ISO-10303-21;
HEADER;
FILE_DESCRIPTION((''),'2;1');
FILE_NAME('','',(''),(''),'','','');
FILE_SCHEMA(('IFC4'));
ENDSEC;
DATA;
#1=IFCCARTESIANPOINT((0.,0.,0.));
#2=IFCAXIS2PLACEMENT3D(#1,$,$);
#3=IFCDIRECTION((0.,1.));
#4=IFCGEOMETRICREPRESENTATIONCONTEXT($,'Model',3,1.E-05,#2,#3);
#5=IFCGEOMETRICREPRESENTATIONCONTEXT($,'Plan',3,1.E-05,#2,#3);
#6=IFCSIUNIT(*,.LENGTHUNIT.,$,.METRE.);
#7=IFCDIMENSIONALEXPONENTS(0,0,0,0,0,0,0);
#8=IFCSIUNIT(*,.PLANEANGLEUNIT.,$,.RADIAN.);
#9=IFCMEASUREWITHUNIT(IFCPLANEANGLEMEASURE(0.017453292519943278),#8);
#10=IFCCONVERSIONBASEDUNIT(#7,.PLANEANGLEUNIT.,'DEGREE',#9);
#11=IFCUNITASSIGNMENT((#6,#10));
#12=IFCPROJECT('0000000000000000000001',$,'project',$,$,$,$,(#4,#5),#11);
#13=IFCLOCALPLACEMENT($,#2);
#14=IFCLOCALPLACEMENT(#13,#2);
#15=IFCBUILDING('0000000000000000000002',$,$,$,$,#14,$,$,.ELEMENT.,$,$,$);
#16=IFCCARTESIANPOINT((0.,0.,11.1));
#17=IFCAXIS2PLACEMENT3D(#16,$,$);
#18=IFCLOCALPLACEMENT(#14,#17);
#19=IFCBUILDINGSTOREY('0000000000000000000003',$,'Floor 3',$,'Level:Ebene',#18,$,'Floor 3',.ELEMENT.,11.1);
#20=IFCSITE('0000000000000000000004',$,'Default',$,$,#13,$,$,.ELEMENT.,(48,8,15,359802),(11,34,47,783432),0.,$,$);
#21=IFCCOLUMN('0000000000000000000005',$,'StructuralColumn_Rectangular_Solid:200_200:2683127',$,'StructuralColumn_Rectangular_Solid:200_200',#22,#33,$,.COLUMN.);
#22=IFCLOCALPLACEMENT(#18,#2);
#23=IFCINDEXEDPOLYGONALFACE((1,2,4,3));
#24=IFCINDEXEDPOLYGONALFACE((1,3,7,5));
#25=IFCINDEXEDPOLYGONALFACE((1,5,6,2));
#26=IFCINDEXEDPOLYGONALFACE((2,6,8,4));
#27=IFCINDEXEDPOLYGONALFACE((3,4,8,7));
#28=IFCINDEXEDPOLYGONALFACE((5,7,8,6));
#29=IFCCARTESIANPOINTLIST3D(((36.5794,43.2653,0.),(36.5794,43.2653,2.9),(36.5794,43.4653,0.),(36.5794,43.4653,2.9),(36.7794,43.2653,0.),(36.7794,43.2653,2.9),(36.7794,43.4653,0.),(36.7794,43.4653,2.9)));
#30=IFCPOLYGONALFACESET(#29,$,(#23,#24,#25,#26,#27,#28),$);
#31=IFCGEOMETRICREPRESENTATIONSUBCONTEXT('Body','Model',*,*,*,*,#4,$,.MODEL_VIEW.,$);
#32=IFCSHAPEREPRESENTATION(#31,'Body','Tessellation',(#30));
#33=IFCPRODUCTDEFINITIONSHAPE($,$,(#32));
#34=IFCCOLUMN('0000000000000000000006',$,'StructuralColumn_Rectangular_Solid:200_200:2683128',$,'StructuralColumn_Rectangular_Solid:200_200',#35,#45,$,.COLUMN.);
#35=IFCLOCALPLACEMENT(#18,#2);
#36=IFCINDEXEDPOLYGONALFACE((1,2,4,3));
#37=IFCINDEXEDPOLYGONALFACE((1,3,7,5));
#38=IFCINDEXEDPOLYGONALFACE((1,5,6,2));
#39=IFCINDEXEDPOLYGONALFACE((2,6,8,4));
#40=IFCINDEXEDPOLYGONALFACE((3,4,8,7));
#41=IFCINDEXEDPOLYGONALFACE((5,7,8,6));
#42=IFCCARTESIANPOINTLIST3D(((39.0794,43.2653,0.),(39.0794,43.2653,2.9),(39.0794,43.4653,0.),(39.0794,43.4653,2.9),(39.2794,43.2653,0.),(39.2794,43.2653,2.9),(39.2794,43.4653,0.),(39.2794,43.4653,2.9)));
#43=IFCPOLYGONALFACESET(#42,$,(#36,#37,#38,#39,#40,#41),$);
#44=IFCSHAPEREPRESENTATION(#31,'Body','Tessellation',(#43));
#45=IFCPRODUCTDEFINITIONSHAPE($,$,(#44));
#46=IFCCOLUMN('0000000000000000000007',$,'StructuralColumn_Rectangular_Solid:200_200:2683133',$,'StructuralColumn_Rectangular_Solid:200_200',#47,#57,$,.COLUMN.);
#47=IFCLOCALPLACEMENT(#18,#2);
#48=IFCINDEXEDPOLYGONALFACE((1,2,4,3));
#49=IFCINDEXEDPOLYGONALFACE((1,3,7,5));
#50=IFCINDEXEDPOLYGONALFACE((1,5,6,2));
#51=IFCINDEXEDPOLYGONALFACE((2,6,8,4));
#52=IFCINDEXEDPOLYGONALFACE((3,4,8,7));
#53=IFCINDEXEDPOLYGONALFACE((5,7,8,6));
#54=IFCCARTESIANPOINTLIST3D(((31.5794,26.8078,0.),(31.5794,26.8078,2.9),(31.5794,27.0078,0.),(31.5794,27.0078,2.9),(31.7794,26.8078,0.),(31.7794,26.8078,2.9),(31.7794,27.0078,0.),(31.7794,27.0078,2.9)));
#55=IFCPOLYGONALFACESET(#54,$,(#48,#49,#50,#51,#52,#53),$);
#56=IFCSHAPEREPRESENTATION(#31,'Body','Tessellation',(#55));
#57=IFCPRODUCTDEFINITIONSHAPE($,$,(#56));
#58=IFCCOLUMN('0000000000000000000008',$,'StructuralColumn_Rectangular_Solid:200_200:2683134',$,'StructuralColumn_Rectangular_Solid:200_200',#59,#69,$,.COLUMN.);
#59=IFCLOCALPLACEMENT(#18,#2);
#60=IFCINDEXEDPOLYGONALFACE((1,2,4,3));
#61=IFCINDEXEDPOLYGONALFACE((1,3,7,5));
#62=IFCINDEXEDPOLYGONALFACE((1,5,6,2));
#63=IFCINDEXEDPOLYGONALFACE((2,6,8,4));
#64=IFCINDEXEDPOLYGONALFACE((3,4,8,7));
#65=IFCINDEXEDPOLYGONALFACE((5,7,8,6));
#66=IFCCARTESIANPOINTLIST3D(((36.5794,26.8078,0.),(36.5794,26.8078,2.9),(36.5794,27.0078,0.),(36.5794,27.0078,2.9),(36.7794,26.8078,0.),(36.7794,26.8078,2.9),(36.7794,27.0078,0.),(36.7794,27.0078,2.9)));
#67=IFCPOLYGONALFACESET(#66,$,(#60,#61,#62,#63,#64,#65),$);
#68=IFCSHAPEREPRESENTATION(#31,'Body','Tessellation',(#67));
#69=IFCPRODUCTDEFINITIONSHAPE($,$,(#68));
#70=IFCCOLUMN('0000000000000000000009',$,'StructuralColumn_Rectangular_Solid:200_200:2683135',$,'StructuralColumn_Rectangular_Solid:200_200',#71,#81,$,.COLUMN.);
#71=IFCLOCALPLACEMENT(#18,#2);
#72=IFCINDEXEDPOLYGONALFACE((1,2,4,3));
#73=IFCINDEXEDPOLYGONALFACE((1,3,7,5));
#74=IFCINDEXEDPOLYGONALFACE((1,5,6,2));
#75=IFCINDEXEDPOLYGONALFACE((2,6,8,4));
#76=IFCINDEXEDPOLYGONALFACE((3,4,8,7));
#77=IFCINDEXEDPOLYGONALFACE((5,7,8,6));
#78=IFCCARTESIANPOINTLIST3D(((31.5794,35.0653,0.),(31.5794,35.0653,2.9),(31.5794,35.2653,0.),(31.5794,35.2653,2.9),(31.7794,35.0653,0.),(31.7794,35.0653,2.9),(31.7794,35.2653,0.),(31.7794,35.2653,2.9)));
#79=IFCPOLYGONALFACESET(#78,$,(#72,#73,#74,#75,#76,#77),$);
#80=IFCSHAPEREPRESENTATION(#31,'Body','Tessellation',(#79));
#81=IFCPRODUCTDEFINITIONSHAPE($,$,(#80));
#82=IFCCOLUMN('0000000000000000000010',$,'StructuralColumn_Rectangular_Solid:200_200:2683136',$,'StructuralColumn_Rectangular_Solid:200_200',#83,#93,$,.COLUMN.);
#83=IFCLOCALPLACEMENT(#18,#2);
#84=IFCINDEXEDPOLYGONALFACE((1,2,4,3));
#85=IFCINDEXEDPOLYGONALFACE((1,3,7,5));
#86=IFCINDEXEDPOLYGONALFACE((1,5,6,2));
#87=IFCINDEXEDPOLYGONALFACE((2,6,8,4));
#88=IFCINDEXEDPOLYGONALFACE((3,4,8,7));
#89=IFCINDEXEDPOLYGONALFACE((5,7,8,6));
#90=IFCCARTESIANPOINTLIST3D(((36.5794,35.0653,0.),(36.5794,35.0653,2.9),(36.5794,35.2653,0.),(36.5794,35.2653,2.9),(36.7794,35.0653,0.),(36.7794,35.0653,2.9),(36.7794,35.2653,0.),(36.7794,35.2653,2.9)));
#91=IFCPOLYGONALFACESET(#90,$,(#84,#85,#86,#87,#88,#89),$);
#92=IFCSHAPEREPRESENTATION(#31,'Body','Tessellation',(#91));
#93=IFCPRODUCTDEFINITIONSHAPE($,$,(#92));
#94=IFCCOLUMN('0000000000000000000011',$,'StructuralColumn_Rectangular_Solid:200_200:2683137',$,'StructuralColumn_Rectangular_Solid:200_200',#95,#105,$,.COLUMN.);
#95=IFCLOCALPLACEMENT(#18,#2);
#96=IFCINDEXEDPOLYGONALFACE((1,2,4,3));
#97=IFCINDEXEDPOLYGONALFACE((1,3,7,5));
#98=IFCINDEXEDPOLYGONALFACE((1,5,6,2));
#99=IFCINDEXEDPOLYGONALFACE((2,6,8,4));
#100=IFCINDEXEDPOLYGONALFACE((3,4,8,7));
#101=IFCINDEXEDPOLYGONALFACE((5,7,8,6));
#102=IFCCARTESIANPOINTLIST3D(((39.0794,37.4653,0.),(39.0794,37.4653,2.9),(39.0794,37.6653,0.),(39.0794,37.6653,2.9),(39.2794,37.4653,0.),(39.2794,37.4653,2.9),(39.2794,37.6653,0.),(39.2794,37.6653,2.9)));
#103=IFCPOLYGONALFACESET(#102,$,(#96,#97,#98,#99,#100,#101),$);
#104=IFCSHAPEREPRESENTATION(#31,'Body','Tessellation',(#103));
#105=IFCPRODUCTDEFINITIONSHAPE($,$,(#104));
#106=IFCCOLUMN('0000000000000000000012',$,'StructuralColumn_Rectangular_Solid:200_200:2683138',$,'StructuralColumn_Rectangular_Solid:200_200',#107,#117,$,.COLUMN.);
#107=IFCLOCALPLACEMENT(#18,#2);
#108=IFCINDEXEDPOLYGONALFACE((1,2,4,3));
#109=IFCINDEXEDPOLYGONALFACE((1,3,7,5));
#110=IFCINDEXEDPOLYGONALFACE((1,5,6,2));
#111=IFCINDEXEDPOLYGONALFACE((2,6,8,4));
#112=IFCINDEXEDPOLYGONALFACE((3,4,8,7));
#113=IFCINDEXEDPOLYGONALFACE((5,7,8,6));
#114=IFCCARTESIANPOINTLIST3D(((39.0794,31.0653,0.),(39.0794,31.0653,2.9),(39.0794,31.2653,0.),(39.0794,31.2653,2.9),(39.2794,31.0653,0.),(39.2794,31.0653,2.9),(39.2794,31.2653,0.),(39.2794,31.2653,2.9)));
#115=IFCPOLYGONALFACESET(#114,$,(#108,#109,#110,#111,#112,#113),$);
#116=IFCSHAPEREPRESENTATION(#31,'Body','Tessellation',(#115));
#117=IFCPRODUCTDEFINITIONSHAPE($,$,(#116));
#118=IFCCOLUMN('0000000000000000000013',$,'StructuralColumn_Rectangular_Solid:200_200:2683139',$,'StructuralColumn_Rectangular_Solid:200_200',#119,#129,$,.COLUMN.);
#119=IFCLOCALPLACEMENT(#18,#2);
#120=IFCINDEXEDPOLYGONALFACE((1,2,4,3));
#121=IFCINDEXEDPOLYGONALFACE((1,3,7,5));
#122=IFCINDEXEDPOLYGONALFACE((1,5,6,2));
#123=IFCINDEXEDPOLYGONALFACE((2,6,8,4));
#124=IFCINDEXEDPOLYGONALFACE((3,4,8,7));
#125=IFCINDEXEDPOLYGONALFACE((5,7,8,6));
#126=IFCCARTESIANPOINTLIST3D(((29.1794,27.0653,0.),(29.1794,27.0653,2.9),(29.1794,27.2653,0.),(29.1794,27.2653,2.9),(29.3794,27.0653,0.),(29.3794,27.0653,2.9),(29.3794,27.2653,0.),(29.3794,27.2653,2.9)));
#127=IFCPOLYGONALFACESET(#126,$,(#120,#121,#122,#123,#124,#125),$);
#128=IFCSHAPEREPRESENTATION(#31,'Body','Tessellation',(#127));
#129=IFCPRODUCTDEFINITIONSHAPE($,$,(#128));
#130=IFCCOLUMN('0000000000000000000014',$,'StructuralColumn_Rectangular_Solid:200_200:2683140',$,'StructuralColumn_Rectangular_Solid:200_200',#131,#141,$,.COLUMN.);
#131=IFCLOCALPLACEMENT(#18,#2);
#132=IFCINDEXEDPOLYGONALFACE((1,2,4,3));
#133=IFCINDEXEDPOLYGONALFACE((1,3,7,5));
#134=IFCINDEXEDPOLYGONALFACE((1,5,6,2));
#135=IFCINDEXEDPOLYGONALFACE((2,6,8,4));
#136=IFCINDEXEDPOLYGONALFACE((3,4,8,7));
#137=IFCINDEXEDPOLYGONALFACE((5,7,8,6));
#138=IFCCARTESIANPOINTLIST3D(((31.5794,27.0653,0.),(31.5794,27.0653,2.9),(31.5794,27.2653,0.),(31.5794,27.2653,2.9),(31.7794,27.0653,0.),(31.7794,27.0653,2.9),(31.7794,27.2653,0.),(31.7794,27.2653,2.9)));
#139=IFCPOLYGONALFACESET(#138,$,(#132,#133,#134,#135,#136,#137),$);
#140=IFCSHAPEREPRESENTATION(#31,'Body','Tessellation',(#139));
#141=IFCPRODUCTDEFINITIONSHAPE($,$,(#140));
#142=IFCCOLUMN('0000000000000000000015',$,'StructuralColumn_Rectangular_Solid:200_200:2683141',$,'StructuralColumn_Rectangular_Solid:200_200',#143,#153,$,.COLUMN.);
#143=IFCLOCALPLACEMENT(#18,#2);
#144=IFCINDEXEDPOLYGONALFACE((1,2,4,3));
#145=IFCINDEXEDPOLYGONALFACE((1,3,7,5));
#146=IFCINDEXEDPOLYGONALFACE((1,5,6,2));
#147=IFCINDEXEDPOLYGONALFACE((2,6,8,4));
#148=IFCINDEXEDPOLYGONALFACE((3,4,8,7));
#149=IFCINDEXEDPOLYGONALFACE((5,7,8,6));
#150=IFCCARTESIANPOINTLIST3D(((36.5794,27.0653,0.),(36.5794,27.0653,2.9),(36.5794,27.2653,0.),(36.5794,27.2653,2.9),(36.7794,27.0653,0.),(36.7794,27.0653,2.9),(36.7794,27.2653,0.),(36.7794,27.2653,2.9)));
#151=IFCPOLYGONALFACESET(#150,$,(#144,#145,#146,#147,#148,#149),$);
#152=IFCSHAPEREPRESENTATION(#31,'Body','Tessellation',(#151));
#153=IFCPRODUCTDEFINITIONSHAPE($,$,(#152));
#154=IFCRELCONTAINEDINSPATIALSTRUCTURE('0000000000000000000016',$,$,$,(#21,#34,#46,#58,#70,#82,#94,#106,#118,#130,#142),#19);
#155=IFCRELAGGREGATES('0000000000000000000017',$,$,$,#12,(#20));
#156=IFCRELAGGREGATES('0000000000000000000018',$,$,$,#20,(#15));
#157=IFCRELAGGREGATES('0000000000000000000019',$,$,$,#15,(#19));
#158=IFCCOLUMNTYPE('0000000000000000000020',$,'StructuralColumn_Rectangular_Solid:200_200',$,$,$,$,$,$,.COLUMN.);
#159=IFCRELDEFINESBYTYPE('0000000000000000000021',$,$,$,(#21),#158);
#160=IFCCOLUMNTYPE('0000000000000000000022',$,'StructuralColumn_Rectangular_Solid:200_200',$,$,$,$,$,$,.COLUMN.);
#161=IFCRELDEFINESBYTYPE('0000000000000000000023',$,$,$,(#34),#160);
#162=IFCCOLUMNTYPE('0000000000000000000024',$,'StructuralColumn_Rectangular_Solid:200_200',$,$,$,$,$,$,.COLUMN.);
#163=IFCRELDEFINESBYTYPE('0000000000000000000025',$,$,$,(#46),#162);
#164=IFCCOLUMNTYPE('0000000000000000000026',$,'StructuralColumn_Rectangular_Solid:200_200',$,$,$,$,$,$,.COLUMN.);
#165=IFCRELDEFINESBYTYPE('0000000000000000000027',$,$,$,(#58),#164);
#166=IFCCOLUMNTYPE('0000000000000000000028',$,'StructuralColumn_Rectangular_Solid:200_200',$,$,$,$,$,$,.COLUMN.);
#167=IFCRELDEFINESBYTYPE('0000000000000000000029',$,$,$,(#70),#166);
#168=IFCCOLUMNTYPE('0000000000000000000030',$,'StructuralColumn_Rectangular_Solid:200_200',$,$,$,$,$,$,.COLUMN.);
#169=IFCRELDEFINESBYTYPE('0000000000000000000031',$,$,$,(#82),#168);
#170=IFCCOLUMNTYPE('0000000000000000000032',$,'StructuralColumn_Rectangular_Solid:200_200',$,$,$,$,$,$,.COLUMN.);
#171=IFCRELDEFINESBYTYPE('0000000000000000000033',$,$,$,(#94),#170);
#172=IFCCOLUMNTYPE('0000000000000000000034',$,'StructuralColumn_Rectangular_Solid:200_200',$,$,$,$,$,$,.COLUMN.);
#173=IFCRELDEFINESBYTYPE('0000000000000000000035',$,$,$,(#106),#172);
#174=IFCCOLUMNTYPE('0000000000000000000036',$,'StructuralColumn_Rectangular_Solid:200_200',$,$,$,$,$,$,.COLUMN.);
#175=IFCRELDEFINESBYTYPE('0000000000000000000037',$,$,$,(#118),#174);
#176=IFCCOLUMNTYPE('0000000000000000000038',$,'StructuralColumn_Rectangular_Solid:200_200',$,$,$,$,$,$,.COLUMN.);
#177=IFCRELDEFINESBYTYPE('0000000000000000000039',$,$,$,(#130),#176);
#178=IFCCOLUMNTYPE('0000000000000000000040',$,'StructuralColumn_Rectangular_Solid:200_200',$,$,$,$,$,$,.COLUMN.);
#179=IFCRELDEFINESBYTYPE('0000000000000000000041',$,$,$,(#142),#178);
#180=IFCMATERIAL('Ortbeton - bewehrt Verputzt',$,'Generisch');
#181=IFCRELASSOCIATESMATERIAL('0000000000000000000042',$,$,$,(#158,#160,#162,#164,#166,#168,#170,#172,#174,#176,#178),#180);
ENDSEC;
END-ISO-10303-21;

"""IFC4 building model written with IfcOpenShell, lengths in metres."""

from ifc_helpers import new_model, entity, si_unit, converted_unit, direction, frame, frame_2d, origin, origin_2d_with_axis, place, context, subcontext, project, spatial, rectangle, extrude, source, transform, mapped, material, material_profile, profile_set, type_object, type_shapes, element, save


model = new_model("IFC4")

# Units and contexts
model_context = context("Model", 3, precision=1e-05, world=origin(), true_north=direction((0.0, 1.0)))
plan_context = context("Plan", 3, precision=1e-05, world=origin(), true_north=direction((0.0, 1.0)))
body_context = subcontext(model_context, "Body", "Model", "MODEL_VIEW")
ifc_project = project(units=[si_unit("LENGTHUNIT", "METRE"), converted_unit("PLANEANGLEUNIT", "DEGREE", entity("IfcPlaneAngleMeasure", 0.017453292519943278), si_unit("PLANEANGLEUNIT", "RADIAN"), dimensions=[0, 0, 0, 0, 0, 0, 0])], contexts=[model_context, plan_context])

# Site, building, storey
site_placement = place(None, origin())
site = spatial("IfcSite", under=ifc_project, at=site_placement, Name="Default", CompositionType="ELEMENT", RefLatitude=(48, 8, 15, 359802), RefLongitude=(11, 34, 47, 783432), RefElevation=0.0)
building_placement = place(site_placement, origin())
building = spatial("IfcBuilding", under=site, at=building_placement, CompositionType="ELEMENT")
storey_placement = place(building_placement, frame((0.0, 0.0, 11.1)))
storey = spatial("IfcBuildingStorey", under=building, at=storey_placement, Name="Floor 3", ObjectType="Level:Ebene", LongName="Floor 3", CompositionType="ELEMENT", Elevation=11.1)

# Columns
ifc_material_1 = material(Name="Ortbeton - bewehrt Verputzt", Category="Generisch")
ifc_material_profile = material_profile(ifc_material_1, rectangle(XDim=0.2, YDim=0.2, at=frame_2d((0.0, 0.0), x_axis=(1.0, 0.0))), Name="200_200")
ifc_profile_set = profile_set([ifc_material_profile], Name="200_200")
column_type_1 = type_object("IfcColumnType", Name="StructuralColumn_Rectangular_Solid:200_200", PredefinedType="COLUMN", material=ifc_profile_set)
shared_shape_1 = source(origin(), body_context, "Body", "SweptSolid", [
    extrude(rectangle(XDim=0.2, YDim=0.2, at=frame_2d((0.0, 0.0), x_axis=(1.0, 0.0))), frame((36.6794, 43.3653, 11.1), z_axis=(0.0, 0.0, 1.0), x_axis=(-1.0, 0.0, 0.0)), (0.0, 0.0, 1.0), 2.9),
])
type_shapes(column_type_1, [shared_shape_1])
column_1_placement = place(storey_placement, frame((0.0, 0.0, -11.1)))
element("IfcColumn", 1, at=column_1_placement, inside=storey, type_object=column_type_1, Name="StructuralColumn_Rectangular_Solid:200_200:2683127", ObjectType="StructuralColumn_Rectangular_Solid:200_200", PredefinedType="COLUMN", context=body_context, shape_type="MappedRepresentation", body=[
    mapped(shared_shape_1, transform((0.0, 0.0, 0.0), scale=1.0)),
])
column_type_2 = type_object("IfcColumnType", Name="StructuralColumn_Rectangular_Solid:200_200", PredefinedType="COLUMN", material=ifc_profile_set)
shared_shape_2 = source(origin(), body_context, "Body", "SweptSolid", [
    extrude(rectangle(XDim=0.2, YDim=0.2, at=frame_2d((0.0, 0.0), x_axis=(1.0, 0.0))), frame((39.1794, 43.3653, 11.1), z_axis=(0.0, 0.0, 1.0), x_axis=(-1.0, 0.0, 0.0)), (0.0, 0.0, 1.0), 2.9),
])
type_shapes(column_type_2, [shared_shape_2])
column_2_placement = place(storey_placement, frame((0.0, 0.0, -11.1)))
element("IfcColumn", 2, at=column_2_placement, inside=storey, type_object=column_type_2, Name="StructuralColumn_Rectangular_Solid:200_200:2683128", ObjectType="StructuralColumn_Rectangular_Solid:200_200", PredefinedType="COLUMN", context=body_context, shape_type="MappedRepresentation", body=[
    mapped(shared_shape_2, transform((0.0, 0.0, 0.0), scale=1.0)),
])
column_type_3 = type_object("IfcColumnType", Name="StructuralColumn_Rectangular_Solid:200_200", PredefinedType="COLUMN", material=ifc_profile_set)
shared_shape_3 = source(origin(), body_context, "Body", "SweptSolid", [
    extrude(rectangle(XDim=0.2, YDim=0.2, at=frame_2d((0.0, 0.0), x_axis=(1.0, 0.0))), frame((31.6794, 26.9078, 11.1), z_axis=(0.0, 0.0, 1.0), x_axis=(-1.0, 0.0, 0.0)), (0.0, 0.0, 1.0), 2.9),
])
type_shapes(column_type_3, [shared_shape_3])
column_3_placement = place(storey_placement, frame((0.0, 0.0, -11.1)))
element("IfcColumn", 3, at=column_3_placement, inside=storey, type_object=column_type_3, Name="StructuralColumn_Rectangular_Solid:200_200:2683133", ObjectType="StructuralColumn_Rectangular_Solid:200_200", PredefinedType="COLUMN", context=body_context, shape_type="MappedRepresentation", body=[
    mapped(shared_shape_3, transform((0.0, 0.0, 0.0), scale=1.0)),
])
column_type_4 = type_object("IfcColumnType", Name="StructuralColumn_Rectangular_Solid:200_200", PredefinedType="COLUMN", material=ifc_profile_set)
shared_shape_4 = source(origin(), body_context, "Body", "SweptSolid", [
    extrude(rectangle(XDim=0.2, YDim=0.2, at=origin_2d_with_axis()), frame((36.6794, 26.9078, 11.1), z_axis=(0.0, 0.0, 1.0), x_axis=(-1.0, 0.0, 0.0)), (0.0, 0.0, 1.0), 2.9),
])
type_shapes(column_type_4, [shared_shape_4])
column_4_placement = place(storey_placement, frame((0.0, 0.0, -11.1)))
element("IfcColumn", 4, at=column_4_placement, inside=storey, type_object=column_type_4, Name="StructuralColumn_Rectangular_Solid:200_200:2683134", ObjectType="StructuralColumn_Rectangular_Solid:200_200", PredefinedType="COLUMN", context=body_context, shape_type="MappedRepresentation", body=[
    mapped(shared_shape_4, transform((0.0, 0.0, 0.0), scale=1.0)),
])
column_type_5 = type_object("IfcColumnType", Name="StructuralColumn_Rectangular_Solid:200_200", PredefinedType="COLUMN", material=ifc_profile_set)
shared_shape_5 = source(origin(), body_context, "Body", "SweptSolid", [
    extrude(rectangle(XDim=0.2, YDim=0.2, at=origin_2d_with_axis()), frame((31.6794, 35.1653, 11.1), z_axis=(0.0, 0.0, 1.0), x_axis=(-1.0, 0.0, 0.0)), (0.0, 0.0, 1.0), 2.9),
])
type_shapes(column_type_5, [shared_shape_5])
column_5_placement = place(storey_placement, frame((0.0, 0.0, -11.1)))
element("IfcColumn", 5, at=column_5_placement, inside=storey, type_object=column_type_5, Name="StructuralColumn_Rectangular_Solid:200_200:2683135", ObjectType="StructuralColumn_Rectangular_Solid:200_200", PredefinedType="COLUMN", context=body_context, shape_type="MappedRepresentation", body=[
    mapped(shared_shape_5, transform((0.0, 0.0, 0.0), scale=1.0)),
])
column_type_6 = type_object("IfcColumnType", Name="StructuralColumn_Rectangular_Solid:200_200", PredefinedType="COLUMN", material=ifc_profile_set)
shared_shape_6 = source(origin(), body_context, "Body", "SweptSolid", [
    extrude(rectangle(XDim=0.2, YDim=0.2, at=origin_2d_with_axis()), frame((36.6794, 35.1653, 11.1), z_axis=(0.0, 0.0, 1.0), x_axis=(-1.0, 0.0, 0.0)), (0.0, 0.0, 1.0), 2.9),
])
type_shapes(column_type_6, [shared_shape_6])
column_6_placement = place(storey_placement, frame((0.0, 0.0, -11.1)))
element("IfcColumn", 6, at=column_6_placement, inside=storey, type_object=column_type_6, Name="StructuralColumn_Rectangular_Solid:200_200:2683136", ObjectType="StructuralColumn_Rectangular_Solid:200_200", PredefinedType="COLUMN", context=body_context, shape_type="MappedRepresentation", body=[
    mapped(shared_shape_6, transform((0.0, 0.0, 0.0), scale=1.0)),
])
column_type_7 = type_object("IfcColumnType", Name="StructuralColumn_Rectangular_Solid:200_200", PredefinedType="COLUMN", material=ifc_profile_set)
shared_shape_7 = source(origin(), body_context, "Body", "SweptSolid", [
    extrude(rectangle(XDim=0.2, YDim=0.2, at=frame_2d((0.0, 0.0), x_axis=(1.0, 0.0))), frame((39.1794, 37.5653, 11.1), z_axis=(0.0, 0.0, 1.0), x_axis=(-1.0, 0.0, 0.0)), (0.0, 0.0, 1.0), 2.9),
])
type_shapes(column_type_7, [shared_shape_7])
column_7_placement = place(storey_placement, frame((0.0, 0.0, -11.1)))
element("IfcColumn", 7, at=column_7_placement, inside=storey, type_object=column_type_7, Name="StructuralColumn_Rectangular_Solid:200_200:2683137", ObjectType="StructuralColumn_Rectangular_Solid:200_200", PredefinedType="COLUMN", context=body_context, shape_type="MappedRepresentation", body=[
    mapped(shared_shape_7, transform((0.0, 0.0, 0.0), scale=1.0)),
])
column_type_8 = type_object("IfcColumnType", Name="StructuralColumn_Rectangular_Solid:200_200", PredefinedType="COLUMN", material=ifc_profile_set)
shared_shape_8 = source(origin(), body_context, "Body", "SweptSolid", [
    extrude(rectangle(XDim=0.2, YDim=0.2, at=frame_2d((0.0, 0.0), x_axis=(1.0, 0.0))), frame((39.1794, 31.1653, 11.1), z_axis=(0.0, 0.0, 1.0), x_axis=(-1.0, 0.0, 0.0)), (0.0, 0.0, 1.0), 2.9),
])
type_shapes(column_type_8, [shared_shape_8])
column_8_placement = place(storey_placement, frame((0.0, 0.0, -11.1)))
element("IfcColumn", 8, at=column_8_placement, inside=storey, type_object=column_type_8, Name="StructuralColumn_Rectangular_Solid:200_200:2683138", ObjectType="StructuralColumn_Rectangular_Solid:200_200", PredefinedType="COLUMN", context=body_context, shape_type="MappedRepresentation", body=[
    mapped(shared_shape_8, transform((0.0, 0.0, 0.0), scale=1.0)),
])
column_type_9 = type_object("IfcColumnType", Name="StructuralColumn_Rectangular_Solid:200_200", PredefinedType="COLUMN", material=ifc_profile_set)
shared_shape_9 = source(origin(), body_context, "Body", "SweptSolid", [
    extrude(rectangle(XDim=0.2, YDim=0.2, at=frame_2d((0.0, 0.0), x_axis=(1.0, 0.0))), frame((29.2794, 27.1653, 11.1), z_axis=(0.0, 0.0, 1.0), x_axis=(-1.0, 0.0, 0.0)), (0.0, 0.0, 1.0), 2.9),
])
type_shapes(column_type_9, [shared_shape_9])
column_9_placement = place(storey_placement, frame((0.0, 0.0, -11.1)))
element("IfcColumn", 9, at=column_9_placement, inside=storey, type_object=column_type_9, Name="StructuralColumn_Rectangular_Solid:200_200:2683139", ObjectType="StructuralColumn_Rectangular_Solid:200_200", PredefinedType="COLUMN", context=body_context, shape_type="MappedRepresentation", body=[
    mapped(shared_shape_9, transform((0.0, 0.0, 0.0), scale=1.0)),
])
column_type_10 = type_object("IfcColumnType", Name="StructuralColumn_Rectangular_Solid:200_200", PredefinedType="COLUMN", material=ifc_profile_set)
shared_shape_10 = source(origin(), body_context, "Body", "SweptSolid", [
    extrude(rectangle(XDim=0.2, YDim=0.2, at=frame_2d((0.0, 0.0), x_axis=(1.0, 0.0))), frame((31.6794, 27.1653, 11.1), z_axis=(0.0, 0.0, 1.0), x_axis=(-1.0, 0.0, 0.0)), (0.0, 0.0, 1.0), 2.9),
])
type_shapes(column_type_10, [shared_shape_10])
column_10_placement = place(storey_placement, frame((0.0, 0.0, -11.1)))
element("IfcColumn", 10, at=column_10_placement, inside=storey, type_object=column_type_10, Name="StructuralColumn_Rectangular_Solid:200_200:2683140", ObjectType="StructuralColumn_Rectangular_Solid:200_200", PredefinedType="COLUMN", context=body_context, shape_type="MappedRepresentation", body=[
    mapped(shared_shape_10, transform((0.0, 0.0, 0.0), scale=1.0)),
])
column_type_11 = type_object("IfcColumnType", Name="StructuralColumn_Rectangular_Solid:200_200", PredefinedType="COLUMN", material=ifc_profile_set)
shared_shape_11 = source(origin(), body_context, "Body", "SweptSolid", [
    extrude(rectangle(XDim=0.2, YDim=0.2, at=origin_2d_with_axis()), frame((36.6794, 27.1653, 11.1), z_axis=(0.0, 0.0, 1.0), x_axis=(-1.0, 0.0, 0.0)), (0.0, 0.0, 1.0), 2.9),
])
type_shapes(column_type_11, [shared_shape_11])
column_11_placement = place(storey_placement, frame((0.0, 0.0, -11.1)))
element("IfcColumn", 11, at=column_11_placement, inside=storey, type_object=column_type_11, Name="StructuralColumn_Rectangular_Solid:200_200:2683141", ObjectType="StructuralColumn_Rectangular_Solid:200_200", PredefinedType="COLUMN", context=body_context, shape_type="MappedRepresentation", body=[
    mapped(shared_shape_11, transform((0.0, 0.0, 0.0), scale=1.0)),
])

save(model, "model.ifc")
